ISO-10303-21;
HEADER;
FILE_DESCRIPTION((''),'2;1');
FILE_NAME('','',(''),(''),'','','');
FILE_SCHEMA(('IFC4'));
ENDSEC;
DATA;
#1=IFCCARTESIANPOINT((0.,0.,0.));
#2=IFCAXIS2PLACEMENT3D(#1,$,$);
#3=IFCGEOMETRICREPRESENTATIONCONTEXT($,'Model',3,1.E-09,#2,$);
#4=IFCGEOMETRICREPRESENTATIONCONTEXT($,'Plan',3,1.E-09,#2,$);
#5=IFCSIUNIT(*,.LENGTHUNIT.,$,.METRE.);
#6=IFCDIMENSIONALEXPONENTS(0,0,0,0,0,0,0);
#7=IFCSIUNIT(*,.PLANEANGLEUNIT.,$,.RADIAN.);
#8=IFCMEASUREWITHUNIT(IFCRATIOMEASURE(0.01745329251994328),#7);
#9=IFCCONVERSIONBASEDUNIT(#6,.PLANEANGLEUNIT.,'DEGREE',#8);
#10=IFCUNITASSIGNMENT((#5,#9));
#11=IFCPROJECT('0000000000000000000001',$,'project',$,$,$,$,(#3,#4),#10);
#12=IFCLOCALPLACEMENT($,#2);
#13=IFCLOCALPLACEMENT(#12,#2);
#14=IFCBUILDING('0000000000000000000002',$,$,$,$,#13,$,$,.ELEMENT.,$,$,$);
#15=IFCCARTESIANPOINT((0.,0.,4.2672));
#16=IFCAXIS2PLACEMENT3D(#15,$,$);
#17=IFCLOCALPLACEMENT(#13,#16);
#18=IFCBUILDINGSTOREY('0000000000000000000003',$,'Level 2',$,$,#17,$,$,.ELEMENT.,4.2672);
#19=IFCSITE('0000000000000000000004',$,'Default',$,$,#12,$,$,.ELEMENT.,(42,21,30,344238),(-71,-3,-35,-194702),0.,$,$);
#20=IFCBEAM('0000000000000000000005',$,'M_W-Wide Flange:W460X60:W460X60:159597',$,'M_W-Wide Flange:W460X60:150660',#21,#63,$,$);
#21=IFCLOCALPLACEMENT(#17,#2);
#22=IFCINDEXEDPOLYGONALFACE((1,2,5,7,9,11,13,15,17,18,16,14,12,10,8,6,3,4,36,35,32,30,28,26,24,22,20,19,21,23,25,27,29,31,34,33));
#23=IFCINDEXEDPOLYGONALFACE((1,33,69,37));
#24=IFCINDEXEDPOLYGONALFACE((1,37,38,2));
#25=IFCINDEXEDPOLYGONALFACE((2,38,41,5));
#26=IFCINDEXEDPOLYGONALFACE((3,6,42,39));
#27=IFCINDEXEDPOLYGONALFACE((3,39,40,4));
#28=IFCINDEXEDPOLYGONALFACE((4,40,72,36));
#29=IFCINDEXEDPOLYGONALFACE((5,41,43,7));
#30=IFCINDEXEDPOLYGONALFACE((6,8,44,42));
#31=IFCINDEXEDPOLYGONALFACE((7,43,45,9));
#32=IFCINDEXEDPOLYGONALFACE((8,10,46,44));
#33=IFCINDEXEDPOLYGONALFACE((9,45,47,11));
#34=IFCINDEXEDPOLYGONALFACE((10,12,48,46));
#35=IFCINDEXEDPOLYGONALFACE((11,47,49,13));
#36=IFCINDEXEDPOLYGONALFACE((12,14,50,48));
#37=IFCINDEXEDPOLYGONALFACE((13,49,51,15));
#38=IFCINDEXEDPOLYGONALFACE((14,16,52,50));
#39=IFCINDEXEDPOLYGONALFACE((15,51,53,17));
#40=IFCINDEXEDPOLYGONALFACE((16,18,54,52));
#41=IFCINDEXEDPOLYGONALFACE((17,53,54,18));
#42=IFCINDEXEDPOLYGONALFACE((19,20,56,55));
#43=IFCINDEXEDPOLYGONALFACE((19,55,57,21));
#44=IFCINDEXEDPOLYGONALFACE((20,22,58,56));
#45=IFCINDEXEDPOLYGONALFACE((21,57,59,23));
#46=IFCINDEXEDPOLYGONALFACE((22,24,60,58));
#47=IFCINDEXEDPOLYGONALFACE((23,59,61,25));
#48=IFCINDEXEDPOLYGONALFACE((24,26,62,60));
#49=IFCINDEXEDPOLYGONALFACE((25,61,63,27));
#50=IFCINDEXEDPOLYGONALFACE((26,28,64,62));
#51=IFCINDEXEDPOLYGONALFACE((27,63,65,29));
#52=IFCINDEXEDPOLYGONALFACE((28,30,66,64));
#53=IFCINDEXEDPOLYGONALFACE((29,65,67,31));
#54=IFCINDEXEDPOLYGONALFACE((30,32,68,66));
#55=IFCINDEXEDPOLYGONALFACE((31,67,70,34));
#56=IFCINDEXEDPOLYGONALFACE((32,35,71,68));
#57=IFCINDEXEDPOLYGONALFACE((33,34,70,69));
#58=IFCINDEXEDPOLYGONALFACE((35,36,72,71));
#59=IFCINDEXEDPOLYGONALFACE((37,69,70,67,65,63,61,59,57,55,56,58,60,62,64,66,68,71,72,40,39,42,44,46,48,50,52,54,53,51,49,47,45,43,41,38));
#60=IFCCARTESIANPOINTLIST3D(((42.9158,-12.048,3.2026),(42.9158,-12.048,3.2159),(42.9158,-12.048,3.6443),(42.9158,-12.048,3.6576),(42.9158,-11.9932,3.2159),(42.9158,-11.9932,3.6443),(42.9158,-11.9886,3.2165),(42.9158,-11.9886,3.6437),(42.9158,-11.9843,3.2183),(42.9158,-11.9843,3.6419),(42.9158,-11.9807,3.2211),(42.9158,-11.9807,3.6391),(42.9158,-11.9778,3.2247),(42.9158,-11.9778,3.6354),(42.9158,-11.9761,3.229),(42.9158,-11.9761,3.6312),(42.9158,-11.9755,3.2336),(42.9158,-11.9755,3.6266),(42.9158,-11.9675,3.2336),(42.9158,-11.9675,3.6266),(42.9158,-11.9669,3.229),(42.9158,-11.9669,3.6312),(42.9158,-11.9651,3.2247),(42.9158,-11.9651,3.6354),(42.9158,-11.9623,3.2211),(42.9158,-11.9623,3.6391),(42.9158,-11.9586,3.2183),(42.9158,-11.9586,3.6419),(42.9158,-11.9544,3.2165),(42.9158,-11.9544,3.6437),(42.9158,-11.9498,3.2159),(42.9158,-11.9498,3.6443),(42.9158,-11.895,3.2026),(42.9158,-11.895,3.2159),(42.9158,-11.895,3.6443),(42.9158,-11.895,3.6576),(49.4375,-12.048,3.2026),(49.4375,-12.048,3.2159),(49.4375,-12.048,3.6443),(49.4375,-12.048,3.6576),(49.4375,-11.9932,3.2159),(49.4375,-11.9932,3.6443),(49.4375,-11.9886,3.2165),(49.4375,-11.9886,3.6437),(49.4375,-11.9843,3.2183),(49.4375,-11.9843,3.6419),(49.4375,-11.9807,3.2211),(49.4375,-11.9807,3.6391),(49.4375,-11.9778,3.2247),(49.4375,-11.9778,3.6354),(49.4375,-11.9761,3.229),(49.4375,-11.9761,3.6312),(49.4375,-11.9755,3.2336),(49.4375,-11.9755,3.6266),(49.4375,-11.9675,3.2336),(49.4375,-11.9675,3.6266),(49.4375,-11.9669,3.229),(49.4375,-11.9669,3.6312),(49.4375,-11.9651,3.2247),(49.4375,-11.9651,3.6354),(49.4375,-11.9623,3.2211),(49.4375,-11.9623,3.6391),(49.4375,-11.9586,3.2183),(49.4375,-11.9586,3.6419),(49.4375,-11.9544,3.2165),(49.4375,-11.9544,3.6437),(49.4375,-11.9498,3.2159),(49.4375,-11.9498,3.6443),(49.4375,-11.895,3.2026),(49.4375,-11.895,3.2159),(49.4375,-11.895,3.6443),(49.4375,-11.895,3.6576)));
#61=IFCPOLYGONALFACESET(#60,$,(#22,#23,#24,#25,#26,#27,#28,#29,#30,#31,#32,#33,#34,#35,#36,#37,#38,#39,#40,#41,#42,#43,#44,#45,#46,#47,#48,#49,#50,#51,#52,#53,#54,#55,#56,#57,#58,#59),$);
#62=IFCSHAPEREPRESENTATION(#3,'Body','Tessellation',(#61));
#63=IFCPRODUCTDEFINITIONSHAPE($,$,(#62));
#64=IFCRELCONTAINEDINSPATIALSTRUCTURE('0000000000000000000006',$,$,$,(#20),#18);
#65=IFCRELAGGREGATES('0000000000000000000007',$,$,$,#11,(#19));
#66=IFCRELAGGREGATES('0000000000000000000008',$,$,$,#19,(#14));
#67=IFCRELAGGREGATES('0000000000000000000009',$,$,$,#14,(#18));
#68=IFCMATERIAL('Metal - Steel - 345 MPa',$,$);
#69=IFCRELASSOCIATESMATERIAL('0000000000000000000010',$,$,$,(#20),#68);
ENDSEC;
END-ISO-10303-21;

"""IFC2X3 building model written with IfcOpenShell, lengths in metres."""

from ifc_helpers import new_model, entity, si_unit, converted_unit, frame, frame_2d, origin, place, context, project, spatial, polyline, circle_curve, parameter, trimmed, segment, composite_curve, outline, extrude, material, element, save


model = new_model("IFC2X3")

# Units and contexts
model_context = context("Model", 3, precision=1e-09, world=origin())
plan_context = context("Plan", 3, precision=1e-09, world=origin())
ifc_project = project(units=[si_unit("LENGTHUNIT", "METRE"), converted_unit("PLANEANGLEUNIT", "DEGREE", entity("IfcRatioMeasure", 0.01745329251994328), si_unit("PLANEANGLEUNIT", "RADIAN"), dimensions=[0, 0, 0, 0, 0, 0, 0])], contexts=[model_context, plan_context])

# Site, building, storey
site_placement = place(None, origin())
site = spatial("IfcSite", under=ifc_project, at=site_placement, Name="Default", CompositionType="ELEMENT", RefLatitude=(42, 21, 30, 344238), RefLongitude=(-71, -3, -35, -194702), RefElevation=0.0)
building_placement = place(site_placement, origin())
building = spatial("IfcBuilding", under=site, at=building_placement, CompositionType="ELEMENT")
storey_placement = place(building_placement, frame((0.0, 0.0, 4.2672)))
storey = spatial("IfcBuildingStorey", under=building, at=storey_placement, Name="Level 2", CompositionType="ELEMENT", Elevation=4.2672)

# Shared definitions
ifc_material = material(Name="Metal - Steel - 345 MPa")

# Beam
beam_1_placement = place(storey_placement, frame((49.5395, -11.9715, 3.6576), z_axis=(0.0, 0.0, 1.0), x_axis=(0.0, 1.0, 0.0)))
element("IfcBeam", 1, at=beam_1_placement, inside=storey, material=ifc_material, Name="M_W-Wide Flange:W460X60:W460X60:159597", ObjectType="M_W-Wide Flange:W460X60:150660", context=model_context, shape_type="SweptSolid", body=[
    extrude(outline(composite_curve([segment(polyline([(0.2142, -0.0765), (0.2275, -0.0765)]), True, "CONTINUOUS"), segment(polyline([(0.2275, -0.0765), (0.2275, 0.0765)]), True, "CONTINUOUS"), segment(polyline([(0.2275, 0.0765), (0.2142, 0.0765)]), True, "CONTINUOUS"), segment(polyline([(0.2142, 0.0765), (0.2142, 0.0217)]), True, "CONTINUOUS"), segment(trimmed(circle_curve(frame_2d((0.1965, 0.0217), x_axis=(1.0, 0.0)), 0.0177), [parameter(270.0)], [parameter(360.0)], True, "PARAMETER"), False, "CONTINUOUS"), segment(polyline([(0.1965, 0.004), (-0.1965, 0.004)]), True, "CONTINUOUS"), segment(trimmed(circle_curve(frame_2d((-0.1965, 0.0217), x_axis=(0.0, -1.0)), 0.0177), [parameter(270.0)], [parameter(360.0)], True, "PARAMETER"), False, "CONTINUOUS"), segment(polyline([(-0.2142, 0.0217), (-0.2142, 0.0765)]), True, "CONTINUOUS"), segment(polyline([(-0.2142, 0.0765), (-0.2275, 0.0765)]), True, "CONTINUOUS"), segment(polyline([(-0.2275, 0.0765), (-0.2275, -0.0765)]), True, "CONTINUOUS"), segment(polyline([(-0.2275, -0.0765), (-0.2142, -0.0765)]), True, "CONTINUOUS"), segment(polyline([(-0.2142, -0.0765), (-0.2142, -0.0217)]), True, "CONTINUOUS"), segment(trimmed(circle_curve(frame_2d((-0.1965, -0.0217), x_axis=(-1.0, 0.0)), 0.0177), [parameter(270.0)], [parameter(360.0)], True, "PARAMETER"), False, "CONTINUOUS"), segment(polyline([(-0.1965, -0.004), (0.1965, -0.004)]), True, "CONTINUOUS"), segment(trimmed(circle_curve(frame_2d((0.1965, -0.0217), x_axis=(0.0, 1.0)), 0.0177), [parameter(270.0)], [parameter(0.0)], True, "PARAMETER"), False, "CONTINUOUS"), segment(polyline([(0.2142, -0.0217), (0.2142, -0.0765)]), True, "CONTINUOUS")], self_intersect=False)), frame((0.0, 6.6237, -0.2275), z_axis=(0.0, -1.0, 0.0), x_axis=(0.0, 0.0, -1.0)), (0.0, 0.0, 1.0), 6.5217),
])

save(model, "model.ifc")
